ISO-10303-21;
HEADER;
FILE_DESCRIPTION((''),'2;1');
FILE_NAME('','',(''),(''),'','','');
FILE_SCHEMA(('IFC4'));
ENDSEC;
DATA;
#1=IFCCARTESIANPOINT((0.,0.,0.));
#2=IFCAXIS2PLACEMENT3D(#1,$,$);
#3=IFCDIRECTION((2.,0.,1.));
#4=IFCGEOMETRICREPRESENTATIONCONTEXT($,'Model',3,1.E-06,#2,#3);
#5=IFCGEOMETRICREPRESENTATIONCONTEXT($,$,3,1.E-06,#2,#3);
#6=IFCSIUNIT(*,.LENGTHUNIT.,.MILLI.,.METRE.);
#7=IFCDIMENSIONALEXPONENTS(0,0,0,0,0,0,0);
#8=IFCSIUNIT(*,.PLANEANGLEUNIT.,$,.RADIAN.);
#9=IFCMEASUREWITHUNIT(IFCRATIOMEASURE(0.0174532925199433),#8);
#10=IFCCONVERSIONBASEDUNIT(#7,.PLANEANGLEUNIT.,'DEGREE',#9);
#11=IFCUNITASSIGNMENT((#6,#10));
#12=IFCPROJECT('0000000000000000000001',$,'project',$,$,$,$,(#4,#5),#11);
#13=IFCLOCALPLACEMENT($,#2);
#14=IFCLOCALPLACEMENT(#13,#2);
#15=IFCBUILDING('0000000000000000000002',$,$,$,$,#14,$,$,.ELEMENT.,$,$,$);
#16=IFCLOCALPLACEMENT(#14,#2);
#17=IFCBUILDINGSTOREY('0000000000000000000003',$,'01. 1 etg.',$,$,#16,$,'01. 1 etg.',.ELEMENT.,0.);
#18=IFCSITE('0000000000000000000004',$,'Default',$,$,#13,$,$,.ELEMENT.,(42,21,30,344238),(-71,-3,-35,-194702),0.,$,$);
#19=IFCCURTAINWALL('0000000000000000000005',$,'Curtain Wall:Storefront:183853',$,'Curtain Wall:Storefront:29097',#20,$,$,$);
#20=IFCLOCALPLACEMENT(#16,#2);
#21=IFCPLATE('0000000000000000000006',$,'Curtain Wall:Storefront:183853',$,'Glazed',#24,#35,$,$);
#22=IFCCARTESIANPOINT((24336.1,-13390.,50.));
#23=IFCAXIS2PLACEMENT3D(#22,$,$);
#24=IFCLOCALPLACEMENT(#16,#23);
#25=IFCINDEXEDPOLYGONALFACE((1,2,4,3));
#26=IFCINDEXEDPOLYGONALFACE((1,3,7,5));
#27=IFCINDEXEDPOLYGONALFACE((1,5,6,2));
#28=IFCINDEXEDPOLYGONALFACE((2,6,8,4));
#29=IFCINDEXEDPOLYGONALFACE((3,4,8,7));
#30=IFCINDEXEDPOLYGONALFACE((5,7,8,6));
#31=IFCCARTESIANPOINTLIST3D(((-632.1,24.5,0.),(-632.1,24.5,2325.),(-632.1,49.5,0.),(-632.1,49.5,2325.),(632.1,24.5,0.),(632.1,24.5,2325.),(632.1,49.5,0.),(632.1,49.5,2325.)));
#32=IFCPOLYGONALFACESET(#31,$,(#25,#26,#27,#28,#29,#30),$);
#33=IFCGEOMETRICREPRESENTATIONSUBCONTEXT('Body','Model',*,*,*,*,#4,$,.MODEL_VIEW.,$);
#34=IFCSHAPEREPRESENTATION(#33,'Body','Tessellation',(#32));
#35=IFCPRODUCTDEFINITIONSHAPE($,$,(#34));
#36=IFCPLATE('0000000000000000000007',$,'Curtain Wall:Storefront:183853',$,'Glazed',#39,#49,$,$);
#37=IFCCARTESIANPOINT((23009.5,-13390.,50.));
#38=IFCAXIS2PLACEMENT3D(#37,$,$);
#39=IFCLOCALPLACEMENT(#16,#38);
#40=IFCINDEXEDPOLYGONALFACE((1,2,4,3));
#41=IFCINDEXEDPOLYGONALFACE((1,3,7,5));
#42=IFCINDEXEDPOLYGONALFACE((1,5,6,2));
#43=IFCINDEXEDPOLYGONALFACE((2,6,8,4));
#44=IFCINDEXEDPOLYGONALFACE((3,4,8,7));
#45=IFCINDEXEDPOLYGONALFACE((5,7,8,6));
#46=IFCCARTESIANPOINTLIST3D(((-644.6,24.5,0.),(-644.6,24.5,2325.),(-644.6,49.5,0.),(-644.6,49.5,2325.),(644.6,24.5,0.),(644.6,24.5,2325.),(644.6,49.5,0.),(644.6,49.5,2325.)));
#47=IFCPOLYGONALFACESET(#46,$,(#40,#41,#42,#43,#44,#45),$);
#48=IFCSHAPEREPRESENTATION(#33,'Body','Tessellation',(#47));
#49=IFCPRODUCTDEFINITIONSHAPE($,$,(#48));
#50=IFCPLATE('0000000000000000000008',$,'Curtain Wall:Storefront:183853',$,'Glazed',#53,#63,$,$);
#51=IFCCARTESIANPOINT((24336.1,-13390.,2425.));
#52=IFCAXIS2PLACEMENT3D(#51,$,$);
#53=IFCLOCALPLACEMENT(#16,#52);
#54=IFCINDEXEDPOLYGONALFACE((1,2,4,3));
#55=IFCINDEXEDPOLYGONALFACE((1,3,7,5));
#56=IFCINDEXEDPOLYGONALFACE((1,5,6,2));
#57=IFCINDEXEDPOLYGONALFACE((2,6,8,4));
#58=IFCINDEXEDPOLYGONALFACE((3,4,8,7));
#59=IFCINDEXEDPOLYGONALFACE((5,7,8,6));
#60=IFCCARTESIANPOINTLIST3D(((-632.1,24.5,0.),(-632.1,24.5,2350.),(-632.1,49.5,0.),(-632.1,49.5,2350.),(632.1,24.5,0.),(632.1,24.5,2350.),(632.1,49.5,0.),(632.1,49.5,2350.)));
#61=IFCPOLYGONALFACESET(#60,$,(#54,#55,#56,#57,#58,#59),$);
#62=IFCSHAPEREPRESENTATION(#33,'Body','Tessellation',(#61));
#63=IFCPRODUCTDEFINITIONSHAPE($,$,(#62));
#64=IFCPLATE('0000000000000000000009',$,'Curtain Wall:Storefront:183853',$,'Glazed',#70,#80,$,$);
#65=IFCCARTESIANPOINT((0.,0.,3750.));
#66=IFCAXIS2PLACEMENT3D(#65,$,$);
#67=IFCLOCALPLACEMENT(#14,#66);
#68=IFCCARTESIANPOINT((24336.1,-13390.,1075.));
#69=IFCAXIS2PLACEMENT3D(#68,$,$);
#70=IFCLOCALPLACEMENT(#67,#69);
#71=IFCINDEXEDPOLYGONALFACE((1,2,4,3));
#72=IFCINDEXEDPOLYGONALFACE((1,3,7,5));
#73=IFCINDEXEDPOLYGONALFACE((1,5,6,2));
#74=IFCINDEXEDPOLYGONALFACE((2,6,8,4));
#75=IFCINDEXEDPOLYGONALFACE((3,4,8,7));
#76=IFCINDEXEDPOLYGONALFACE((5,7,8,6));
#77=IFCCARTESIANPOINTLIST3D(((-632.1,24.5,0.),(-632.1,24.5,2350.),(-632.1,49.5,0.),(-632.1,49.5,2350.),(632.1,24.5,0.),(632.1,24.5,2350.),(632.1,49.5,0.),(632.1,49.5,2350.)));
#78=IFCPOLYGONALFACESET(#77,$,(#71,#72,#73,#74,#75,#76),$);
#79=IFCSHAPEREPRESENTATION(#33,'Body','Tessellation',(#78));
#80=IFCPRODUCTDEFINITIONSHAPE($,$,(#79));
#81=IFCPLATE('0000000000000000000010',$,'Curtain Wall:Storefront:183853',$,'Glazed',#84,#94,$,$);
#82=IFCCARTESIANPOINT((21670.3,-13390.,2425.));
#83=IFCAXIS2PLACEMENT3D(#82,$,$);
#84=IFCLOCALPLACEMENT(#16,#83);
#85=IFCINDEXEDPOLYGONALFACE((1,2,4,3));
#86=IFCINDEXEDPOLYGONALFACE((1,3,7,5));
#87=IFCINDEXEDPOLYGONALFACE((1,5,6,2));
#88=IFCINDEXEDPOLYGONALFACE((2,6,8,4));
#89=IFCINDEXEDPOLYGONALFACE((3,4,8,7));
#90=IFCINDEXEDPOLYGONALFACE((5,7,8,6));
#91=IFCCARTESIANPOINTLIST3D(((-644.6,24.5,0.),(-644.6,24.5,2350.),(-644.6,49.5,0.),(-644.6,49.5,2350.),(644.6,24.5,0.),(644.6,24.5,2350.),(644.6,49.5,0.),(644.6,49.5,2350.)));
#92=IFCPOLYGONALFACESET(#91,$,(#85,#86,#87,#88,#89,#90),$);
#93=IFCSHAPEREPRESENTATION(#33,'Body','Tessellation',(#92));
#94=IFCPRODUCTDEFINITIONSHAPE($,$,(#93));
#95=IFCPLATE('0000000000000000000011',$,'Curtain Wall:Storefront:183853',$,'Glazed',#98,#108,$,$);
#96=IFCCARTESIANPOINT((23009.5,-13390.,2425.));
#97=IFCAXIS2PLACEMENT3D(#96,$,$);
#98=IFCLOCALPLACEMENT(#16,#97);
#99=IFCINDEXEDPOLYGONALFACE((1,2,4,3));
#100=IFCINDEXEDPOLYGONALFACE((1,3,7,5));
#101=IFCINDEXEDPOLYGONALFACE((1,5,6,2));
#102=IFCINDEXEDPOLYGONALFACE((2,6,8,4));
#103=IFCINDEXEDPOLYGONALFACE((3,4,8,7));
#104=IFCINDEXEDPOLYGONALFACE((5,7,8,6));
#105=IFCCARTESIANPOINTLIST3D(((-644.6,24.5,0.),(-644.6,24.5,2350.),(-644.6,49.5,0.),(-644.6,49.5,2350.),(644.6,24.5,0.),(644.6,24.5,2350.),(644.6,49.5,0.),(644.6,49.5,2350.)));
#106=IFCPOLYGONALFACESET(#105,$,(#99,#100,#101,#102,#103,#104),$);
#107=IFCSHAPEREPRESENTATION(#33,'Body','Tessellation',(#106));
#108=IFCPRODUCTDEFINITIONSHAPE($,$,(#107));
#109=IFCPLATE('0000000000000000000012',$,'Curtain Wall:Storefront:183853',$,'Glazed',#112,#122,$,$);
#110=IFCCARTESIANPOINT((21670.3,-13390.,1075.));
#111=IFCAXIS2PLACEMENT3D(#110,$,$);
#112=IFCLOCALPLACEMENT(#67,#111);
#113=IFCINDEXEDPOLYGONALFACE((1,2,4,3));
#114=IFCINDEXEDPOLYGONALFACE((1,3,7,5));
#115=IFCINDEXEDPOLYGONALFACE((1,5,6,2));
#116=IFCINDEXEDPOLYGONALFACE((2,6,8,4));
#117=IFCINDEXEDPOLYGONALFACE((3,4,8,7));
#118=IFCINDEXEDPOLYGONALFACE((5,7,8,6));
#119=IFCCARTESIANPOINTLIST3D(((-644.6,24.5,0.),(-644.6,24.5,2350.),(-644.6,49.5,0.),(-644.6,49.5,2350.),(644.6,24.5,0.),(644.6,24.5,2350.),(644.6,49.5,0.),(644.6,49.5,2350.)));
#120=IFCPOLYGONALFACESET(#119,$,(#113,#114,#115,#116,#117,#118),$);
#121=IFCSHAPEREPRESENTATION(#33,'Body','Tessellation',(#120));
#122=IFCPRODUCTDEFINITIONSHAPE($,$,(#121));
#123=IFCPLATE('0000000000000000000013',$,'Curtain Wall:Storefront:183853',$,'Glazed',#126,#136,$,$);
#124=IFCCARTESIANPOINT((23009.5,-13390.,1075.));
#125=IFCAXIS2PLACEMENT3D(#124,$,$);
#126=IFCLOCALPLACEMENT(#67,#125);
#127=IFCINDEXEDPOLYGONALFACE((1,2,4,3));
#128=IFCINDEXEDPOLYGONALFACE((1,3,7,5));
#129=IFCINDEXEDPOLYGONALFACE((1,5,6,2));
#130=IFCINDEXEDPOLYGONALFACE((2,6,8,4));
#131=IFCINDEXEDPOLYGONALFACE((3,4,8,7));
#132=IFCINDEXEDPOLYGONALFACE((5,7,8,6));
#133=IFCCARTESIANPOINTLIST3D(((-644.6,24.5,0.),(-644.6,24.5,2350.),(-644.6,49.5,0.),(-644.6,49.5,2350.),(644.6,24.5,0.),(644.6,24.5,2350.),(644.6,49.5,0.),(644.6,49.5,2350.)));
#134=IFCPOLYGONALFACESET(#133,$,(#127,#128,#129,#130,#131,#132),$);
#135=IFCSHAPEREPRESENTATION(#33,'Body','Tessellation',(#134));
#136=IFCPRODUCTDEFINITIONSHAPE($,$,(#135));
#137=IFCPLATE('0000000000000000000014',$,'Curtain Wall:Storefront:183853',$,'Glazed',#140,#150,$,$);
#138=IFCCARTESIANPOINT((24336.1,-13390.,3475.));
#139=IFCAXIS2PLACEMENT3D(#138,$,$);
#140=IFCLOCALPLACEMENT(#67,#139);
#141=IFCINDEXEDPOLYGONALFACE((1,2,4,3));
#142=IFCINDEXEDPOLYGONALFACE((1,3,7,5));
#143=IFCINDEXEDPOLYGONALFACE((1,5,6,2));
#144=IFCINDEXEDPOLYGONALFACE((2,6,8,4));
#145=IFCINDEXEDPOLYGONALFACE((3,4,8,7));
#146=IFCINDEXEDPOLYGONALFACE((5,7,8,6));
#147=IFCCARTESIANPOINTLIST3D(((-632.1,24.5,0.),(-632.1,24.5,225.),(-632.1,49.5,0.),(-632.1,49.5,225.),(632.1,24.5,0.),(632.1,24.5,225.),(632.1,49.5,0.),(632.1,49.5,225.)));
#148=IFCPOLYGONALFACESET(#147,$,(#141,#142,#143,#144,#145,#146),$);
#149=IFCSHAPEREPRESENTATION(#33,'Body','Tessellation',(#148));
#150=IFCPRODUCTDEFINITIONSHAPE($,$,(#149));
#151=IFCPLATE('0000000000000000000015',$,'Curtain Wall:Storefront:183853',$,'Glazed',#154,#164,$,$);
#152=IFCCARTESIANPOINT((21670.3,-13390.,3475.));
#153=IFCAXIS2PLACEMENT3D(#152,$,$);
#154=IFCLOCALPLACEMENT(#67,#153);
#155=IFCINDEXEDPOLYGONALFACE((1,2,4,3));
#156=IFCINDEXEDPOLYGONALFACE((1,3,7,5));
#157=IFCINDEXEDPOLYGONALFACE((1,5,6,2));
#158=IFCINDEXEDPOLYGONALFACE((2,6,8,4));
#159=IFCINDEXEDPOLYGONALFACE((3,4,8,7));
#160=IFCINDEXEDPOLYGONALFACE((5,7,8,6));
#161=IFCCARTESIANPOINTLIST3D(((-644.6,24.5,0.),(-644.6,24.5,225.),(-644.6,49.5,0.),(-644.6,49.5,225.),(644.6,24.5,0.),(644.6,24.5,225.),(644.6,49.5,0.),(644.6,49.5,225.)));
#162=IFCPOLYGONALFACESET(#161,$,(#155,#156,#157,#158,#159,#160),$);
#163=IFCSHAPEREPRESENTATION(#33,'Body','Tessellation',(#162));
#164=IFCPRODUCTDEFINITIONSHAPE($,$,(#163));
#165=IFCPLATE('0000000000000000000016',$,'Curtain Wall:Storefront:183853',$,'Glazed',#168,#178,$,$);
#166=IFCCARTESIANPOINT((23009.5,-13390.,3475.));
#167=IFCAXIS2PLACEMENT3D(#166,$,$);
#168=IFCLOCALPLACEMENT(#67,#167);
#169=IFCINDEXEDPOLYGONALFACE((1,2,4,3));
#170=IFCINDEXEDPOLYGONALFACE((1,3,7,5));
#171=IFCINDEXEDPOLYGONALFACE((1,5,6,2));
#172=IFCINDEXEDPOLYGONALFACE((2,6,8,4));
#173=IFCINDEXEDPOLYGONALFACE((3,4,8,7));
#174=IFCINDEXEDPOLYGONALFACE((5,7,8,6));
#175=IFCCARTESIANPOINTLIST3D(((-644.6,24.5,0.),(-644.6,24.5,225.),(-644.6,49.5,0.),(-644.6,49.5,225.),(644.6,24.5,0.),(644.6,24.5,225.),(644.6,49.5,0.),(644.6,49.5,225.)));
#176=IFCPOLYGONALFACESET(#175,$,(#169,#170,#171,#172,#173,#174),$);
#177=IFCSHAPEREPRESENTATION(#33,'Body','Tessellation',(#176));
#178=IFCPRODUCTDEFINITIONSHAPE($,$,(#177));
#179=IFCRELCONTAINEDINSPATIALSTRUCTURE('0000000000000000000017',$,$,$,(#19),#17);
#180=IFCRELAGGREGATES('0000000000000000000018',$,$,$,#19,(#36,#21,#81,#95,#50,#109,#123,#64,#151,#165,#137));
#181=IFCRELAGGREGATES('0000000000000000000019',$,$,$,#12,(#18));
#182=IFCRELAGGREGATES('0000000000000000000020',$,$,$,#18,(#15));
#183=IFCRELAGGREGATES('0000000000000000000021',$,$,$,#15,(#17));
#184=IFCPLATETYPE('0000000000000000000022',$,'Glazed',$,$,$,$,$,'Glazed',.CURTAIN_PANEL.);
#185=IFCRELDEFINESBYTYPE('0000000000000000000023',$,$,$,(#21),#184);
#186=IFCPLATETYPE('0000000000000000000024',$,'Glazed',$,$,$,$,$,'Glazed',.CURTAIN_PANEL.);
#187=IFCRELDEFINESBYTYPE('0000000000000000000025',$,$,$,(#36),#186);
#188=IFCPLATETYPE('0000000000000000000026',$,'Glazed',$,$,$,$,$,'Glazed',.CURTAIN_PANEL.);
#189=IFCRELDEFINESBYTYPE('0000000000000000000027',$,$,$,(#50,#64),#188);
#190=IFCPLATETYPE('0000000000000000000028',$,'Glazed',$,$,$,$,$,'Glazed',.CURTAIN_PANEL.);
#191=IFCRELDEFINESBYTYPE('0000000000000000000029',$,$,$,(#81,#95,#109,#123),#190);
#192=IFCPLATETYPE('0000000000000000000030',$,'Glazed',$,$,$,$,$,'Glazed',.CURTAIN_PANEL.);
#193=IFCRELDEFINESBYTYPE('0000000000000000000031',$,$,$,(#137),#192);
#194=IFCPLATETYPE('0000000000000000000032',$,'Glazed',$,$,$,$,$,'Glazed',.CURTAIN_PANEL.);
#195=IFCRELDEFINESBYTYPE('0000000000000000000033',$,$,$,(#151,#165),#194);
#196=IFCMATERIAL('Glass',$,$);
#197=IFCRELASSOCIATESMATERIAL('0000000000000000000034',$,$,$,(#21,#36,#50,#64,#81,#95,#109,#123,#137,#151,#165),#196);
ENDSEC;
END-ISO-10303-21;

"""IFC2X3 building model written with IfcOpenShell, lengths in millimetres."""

from ifc_helpers import new_model, entity, si_unit, converted_unit, direction, frame, origin, origin_2d_with_axis, place, context, subcontext, project, spatial, rectangle, extrude, source, transform, mapped, material, type_object, type_shapes, element, aggregate, save


model = new_model("IFC2X3")

# Units and contexts
model_context = context("Model", 3, precision=1e-06, world=origin(), true_north=direction((2.0, 0.0, 1.0)))
context_of_model = context(None, 3, precision=1e-06, world=origin(), true_north=direction((2.0, 0.0, 1.0)))
body_context = subcontext(model_context, "Body", "Model", "MODEL_VIEW")
ifc_project = project(units=[si_unit("LENGTHUNIT", "METRE", prefix="MILLI"), converted_unit("PLANEANGLEUNIT", "DEGREE", entity("IfcRatioMeasure", 0.0174532925199433), si_unit("PLANEANGLEUNIT", "RADIAN"), dimensions=[0, 0, 0, 0, 0, 0, 0])], contexts=[model_context, context_of_model])

# Site, building, storey
site_placement = place(None, origin())
site = spatial("IfcSite", under=ifc_project, at=site_placement, Name="Default", CompositionType="ELEMENT", RefLatitude=(42, 21, 30, 344238), RefLongitude=(-71, -3, -35, -194702), RefElevation=0.0)
building_placement = place(site_placement, origin())
building = spatial("IfcBuilding", under=site, at=building_placement, CompositionType="ELEMENT")
storey_placement = place(building_placement, origin())
storey = spatial("IfcBuildingStorey", under=building, at=storey_placement, Name="01. 1 etg.", LongName="01. 1 etg.", CompositionType="ELEMENT", Elevation=0.0)

# Curtain wall, plates
curtain_wall_placement = place(storey_placement, origin())
curtain_wall = element("IfcCurtainWall", 1, at=curtain_wall_placement, inside=storey, Name="Curtain Wall:Storefront:183853", ObjectType="Curtain Wall:Storefront:29097")
ifc_material_1 = material(Name="Glass")
plate_type_1 = type_object("IfcPlateType", Name="Glazed", ElementType="Glazed", PredefinedType="CURTAIN_PANEL")
shared_shape_1 = source(origin(), body_context, "Body", "SweptSolid", [
    extrude(rectangle(XDim=25.0, YDim=1264.2, at=origin_2d_with_axis()), frame((0.0, 37.0, 0.0), z_axis=(0.0, 0.0, 1.0), x_axis=(0.0, 1.0, 0.0)), (0.0, 0.0, 1.0), 2325.0),
])
type_shapes(plate_type_1, [shared_shape_1])
plate_1_placement = place(storey_placement, frame((24336.1, -13390.0, 50.0)))
plate_1 = element("IfcPlate", 2, at=plate_1_placement, type_object=plate_type_1, material=ifc_material_1, Name="Curtain Wall:Storefront:183853", ObjectType="Glazed", context=body_context, shape_type="MappedRepresentation", body=[
    mapped(shared_shape_1, transform((0.0, 0.0, 0.0), scale=1.0)),
])
plate_type_2 = type_object("IfcPlateType", Name="Glazed", ElementType="Glazed", PredefinedType="CURTAIN_PANEL")
shared_shape_2 = source(origin(), body_context, "Body", "SweptSolid", [
    extrude(rectangle(XDim=25.0, YDim=1289.2, at=origin_2d_with_axis()), frame((0.0, 37.0, 0.0), z_axis=(0.0, 0.0, 1.0), x_axis=(0.0, 1.0, 0.0)), (0.0, 0.0, 1.0), 2325.0),
])
type_shapes(plate_type_2, [shared_shape_2])
plate_2_placement = place(storey_placement, frame((23009.5, -13390.0, 50.0)))
plate_2 = element("IfcPlate", 3, at=plate_2_placement, type_object=plate_type_2, material=ifc_material_1, Name="Curtain Wall:Storefront:183853", ObjectType="Glazed", context=body_context, shape_type="MappedRepresentation", body=[
    mapped(shared_shape_2, transform((0.0, 0.0, 0.0), scale=1.0)),
])
plate_type_3 = type_object("IfcPlateType", Name="Glazed", ElementType="Glazed", PredefinedType="CURTAIN_PANEL")
shared_shape_3 = source(origin(), body_context, "Body", "SweptSolid", [
    extrude(rectangle(XDim=25.0, YDim=1264.2, at=origin_2d_with_axis()), frame((0.0, 37.0, 0.0), z_axis=(0.0, 0.0, 1.0), x_axis=(0.0, 1.0, 0.0)), (0.0, 0.0, 1.0), 2350.0),
])
type_shapes(plate_type_3, [shared_shape_3])
plate_3_placement = place(storey_placement, frame((24336.1, -13390.0, 2425.0)))
plate_3 = element("IfcPlate", 4, at=plate_3_placement, type_object=plate_type_3, material=ifc_material_1, Name="Curtain Wall:Storefront:183853", ObjectType="Glazed", context=body_context, shape_type="MappedRepresentation", body=[
    mapped(shared_shape_3, transform((0.0, 0.0, 0.0), scale=1.0)),
])
placement = place(building_placement, frame((0.0, 0.0, 3750.0)))
plate_4_placement = place(placement, frame((24336.1, -13390.0, 1075.0)))
plate_4 = element("IfcPlate", 5, at=plate_4_placement, type_object=plate_type_3, material=ifc_material_1, Name="Curtain Wall:Storefront:183853", ObjectType="Glazed", context=body_context, shape_type="MappedRepresentation", body=[
    mapped(shared_shape_3, transform((0.0, 0.0, 0.0), scale=1.0)),
])
plate_type_4 = type_object("IfcPlateType", Name="Glazed", ElementType="Glazed", PredefinedType="CURTAIN_PANEL")
shared_shape_4 = source(origin(), body_context, "Body", "SweptSolid", [
    extrude(rectangle(XDim=25.0, YDim=1289.2, at=origin_2d_with_axis()), frame((0.0, 37.0, 0.0), z_axis=(0.0, 0.0, 1.0), x_axis=(0.0, 1.0, 0.0)), (0.0, 0.0, 1.0), 2350.0),
])
type_shapes(plate_type_4, [shared_shape_4])
plate_5_placement = place(storey_placement, frame((21670.3, -13390.0, 2425.0)))
plate_5 = element("IfcPlate", 6, at=plate_5_placement, type_object=plate_type_4, material=ifc_material_1, Name="Curtain Wall:Storefront:183853", ObjectType="Glazed", context=body_context, shape_type="MappedRepresentation", body=[
    mapped(shared_shape_4, transform((0.0, 0.0, 0.0), scale=1.0)),
])
plate_6_placement = place(storey_placement, frame((23009.5, -13390.0, 2425.0)))
plate_6 = element("IfcPlate", 7, at=plate_6_placement, type_object=plate_type_4, material=ifc_material_1, Name="Curtain Wall:Storefront:183853", ObjectType="Glazed", context=body_context, shape_type="MappedRepresentation", body=[
    mapped(shared_shape_4, transform((0.0, 0.0, 0.0), scale=1.0)),
])
plate_7_placement = place(placement, frame((21670.3, -13390.0, 1075.0)))
plate_7 = element("IfcPlate", 8, at=plate_7_placement, type_object=plate_type_4, material=ifc_material_1, Name="Curtain Wall:Storefront:183853", ObjectType="Glazed", context=body_context, shape_type="MappedRepresentation", body=[
    mapped(shared_shape_4, transform((0.0, 0.0, 0.0), scale=1.0)),
])
plate_8_placement = place(placement, frame((23009.5, -13390.0, 1075.0)))
plate_8 = element("IfcPlate", 9, at=plate_8_placement, type_object=plate_type_4, material=ifc_material_1, Name="Curtain Wall:Storefront:183853", ObjectType="Glazed", context=body_context, shape_type="MappedRepresentation", body=[
    mapped(shared_shape_4, transform((0.0, 0.0, 0.0), scale=1.0)),
])
plate_type_5 = type_object("IfcPlateType", Name="Glazed", ElementType="Glazed", PredefinedType="CURTAIN_PANEL")
shared_shape_5 = source(origin(), body_context, "Body", "SweptSolid", [
    extrude(rectangle(XDim=25.0, YDim=1264.2, at=origin_2d_with_axis()), frame((0.0, 37.0, 0.0), z_axis=(0.0, 0.0, 1.0), x_axis=(0.0, 1.0, 0.0)), (0.0, 0.0, 1.0), 225.0),
])
type_shapes(plate_type_5, [shared_shape_5])
plate_9_placement = place(placement, frame((24336.1, -13390.0, 3475.0)))
plate_9 = element("IfcPlate", 10, at=plate_9_placement, type_object=plate_type_5, material=ifc_material_1, Name="Curtain Wall:Storefront:183853", ObjectType="Glazed", context=body_context, shape_type="MappedRepresentation", body=[
    mapped(shared_shape_5, transform((0.0, 0.0, 0.0), scale=1.0)),
])
plate_type_6 = type_object("IfcPlateType", Name="Glazed", ElementType="Glazed", PredefinedType="CURTAIN_PANEL")
shared_shape_6 = source(origin(), body_context, "Body", "SweptSolid", [
    extrude(rectangle(XDim=25.0, YDim=1289.2, at=origin_2d_with_axis()), frame((0.0, 37.0, 0.0), z_axis=(0.0, 0.0, 1.0), x_axis=(0.0, 1.0, 0.0)), (0.0, 0.0, 1.0), 225.0),
])
type_shapes(plate_type_6, [shared_shape_6])
plate_10_placement = place(placement, frame((21670.3, -13390.0, 3475.0)))
plate_10 = element("IfcPlate", 11, at=plate_10_placement, type_object=plate_type_6, material=ifc_material_1, Name="Curtain Wall:Storefront:183853", ObjectType="Glazed", context=body_context, shape_type="MappedRepresentation", body=[
    mapped(shared_shape_6, transform((0.0, 0.0, 0.0), scale=1.0)),
])
plate_11_placement = place(placement, frame((23009.5, -13390.0, 3475.0)))
plate_11 = element("IfcPlate", 12, at=plate_11_placement, type_object=plate_type_6, material=ifc_material_1, Name="Curtain Wall:Storefront:183853", ObjectType="Glazed", context=body_context, shape_type="MappedRepresentation", body=[
    mapped(shared_shape_6, transform((0.0, 0.0, 0.0), scale=1.0)),
])
aggregate(curtain_wall, [plate_2, plate_1, plate_5, plate_6, plate_3, plate_7, plate_8, plate_4, plate_10, plate_11, plate_9])

save(model, "model.ifc")
